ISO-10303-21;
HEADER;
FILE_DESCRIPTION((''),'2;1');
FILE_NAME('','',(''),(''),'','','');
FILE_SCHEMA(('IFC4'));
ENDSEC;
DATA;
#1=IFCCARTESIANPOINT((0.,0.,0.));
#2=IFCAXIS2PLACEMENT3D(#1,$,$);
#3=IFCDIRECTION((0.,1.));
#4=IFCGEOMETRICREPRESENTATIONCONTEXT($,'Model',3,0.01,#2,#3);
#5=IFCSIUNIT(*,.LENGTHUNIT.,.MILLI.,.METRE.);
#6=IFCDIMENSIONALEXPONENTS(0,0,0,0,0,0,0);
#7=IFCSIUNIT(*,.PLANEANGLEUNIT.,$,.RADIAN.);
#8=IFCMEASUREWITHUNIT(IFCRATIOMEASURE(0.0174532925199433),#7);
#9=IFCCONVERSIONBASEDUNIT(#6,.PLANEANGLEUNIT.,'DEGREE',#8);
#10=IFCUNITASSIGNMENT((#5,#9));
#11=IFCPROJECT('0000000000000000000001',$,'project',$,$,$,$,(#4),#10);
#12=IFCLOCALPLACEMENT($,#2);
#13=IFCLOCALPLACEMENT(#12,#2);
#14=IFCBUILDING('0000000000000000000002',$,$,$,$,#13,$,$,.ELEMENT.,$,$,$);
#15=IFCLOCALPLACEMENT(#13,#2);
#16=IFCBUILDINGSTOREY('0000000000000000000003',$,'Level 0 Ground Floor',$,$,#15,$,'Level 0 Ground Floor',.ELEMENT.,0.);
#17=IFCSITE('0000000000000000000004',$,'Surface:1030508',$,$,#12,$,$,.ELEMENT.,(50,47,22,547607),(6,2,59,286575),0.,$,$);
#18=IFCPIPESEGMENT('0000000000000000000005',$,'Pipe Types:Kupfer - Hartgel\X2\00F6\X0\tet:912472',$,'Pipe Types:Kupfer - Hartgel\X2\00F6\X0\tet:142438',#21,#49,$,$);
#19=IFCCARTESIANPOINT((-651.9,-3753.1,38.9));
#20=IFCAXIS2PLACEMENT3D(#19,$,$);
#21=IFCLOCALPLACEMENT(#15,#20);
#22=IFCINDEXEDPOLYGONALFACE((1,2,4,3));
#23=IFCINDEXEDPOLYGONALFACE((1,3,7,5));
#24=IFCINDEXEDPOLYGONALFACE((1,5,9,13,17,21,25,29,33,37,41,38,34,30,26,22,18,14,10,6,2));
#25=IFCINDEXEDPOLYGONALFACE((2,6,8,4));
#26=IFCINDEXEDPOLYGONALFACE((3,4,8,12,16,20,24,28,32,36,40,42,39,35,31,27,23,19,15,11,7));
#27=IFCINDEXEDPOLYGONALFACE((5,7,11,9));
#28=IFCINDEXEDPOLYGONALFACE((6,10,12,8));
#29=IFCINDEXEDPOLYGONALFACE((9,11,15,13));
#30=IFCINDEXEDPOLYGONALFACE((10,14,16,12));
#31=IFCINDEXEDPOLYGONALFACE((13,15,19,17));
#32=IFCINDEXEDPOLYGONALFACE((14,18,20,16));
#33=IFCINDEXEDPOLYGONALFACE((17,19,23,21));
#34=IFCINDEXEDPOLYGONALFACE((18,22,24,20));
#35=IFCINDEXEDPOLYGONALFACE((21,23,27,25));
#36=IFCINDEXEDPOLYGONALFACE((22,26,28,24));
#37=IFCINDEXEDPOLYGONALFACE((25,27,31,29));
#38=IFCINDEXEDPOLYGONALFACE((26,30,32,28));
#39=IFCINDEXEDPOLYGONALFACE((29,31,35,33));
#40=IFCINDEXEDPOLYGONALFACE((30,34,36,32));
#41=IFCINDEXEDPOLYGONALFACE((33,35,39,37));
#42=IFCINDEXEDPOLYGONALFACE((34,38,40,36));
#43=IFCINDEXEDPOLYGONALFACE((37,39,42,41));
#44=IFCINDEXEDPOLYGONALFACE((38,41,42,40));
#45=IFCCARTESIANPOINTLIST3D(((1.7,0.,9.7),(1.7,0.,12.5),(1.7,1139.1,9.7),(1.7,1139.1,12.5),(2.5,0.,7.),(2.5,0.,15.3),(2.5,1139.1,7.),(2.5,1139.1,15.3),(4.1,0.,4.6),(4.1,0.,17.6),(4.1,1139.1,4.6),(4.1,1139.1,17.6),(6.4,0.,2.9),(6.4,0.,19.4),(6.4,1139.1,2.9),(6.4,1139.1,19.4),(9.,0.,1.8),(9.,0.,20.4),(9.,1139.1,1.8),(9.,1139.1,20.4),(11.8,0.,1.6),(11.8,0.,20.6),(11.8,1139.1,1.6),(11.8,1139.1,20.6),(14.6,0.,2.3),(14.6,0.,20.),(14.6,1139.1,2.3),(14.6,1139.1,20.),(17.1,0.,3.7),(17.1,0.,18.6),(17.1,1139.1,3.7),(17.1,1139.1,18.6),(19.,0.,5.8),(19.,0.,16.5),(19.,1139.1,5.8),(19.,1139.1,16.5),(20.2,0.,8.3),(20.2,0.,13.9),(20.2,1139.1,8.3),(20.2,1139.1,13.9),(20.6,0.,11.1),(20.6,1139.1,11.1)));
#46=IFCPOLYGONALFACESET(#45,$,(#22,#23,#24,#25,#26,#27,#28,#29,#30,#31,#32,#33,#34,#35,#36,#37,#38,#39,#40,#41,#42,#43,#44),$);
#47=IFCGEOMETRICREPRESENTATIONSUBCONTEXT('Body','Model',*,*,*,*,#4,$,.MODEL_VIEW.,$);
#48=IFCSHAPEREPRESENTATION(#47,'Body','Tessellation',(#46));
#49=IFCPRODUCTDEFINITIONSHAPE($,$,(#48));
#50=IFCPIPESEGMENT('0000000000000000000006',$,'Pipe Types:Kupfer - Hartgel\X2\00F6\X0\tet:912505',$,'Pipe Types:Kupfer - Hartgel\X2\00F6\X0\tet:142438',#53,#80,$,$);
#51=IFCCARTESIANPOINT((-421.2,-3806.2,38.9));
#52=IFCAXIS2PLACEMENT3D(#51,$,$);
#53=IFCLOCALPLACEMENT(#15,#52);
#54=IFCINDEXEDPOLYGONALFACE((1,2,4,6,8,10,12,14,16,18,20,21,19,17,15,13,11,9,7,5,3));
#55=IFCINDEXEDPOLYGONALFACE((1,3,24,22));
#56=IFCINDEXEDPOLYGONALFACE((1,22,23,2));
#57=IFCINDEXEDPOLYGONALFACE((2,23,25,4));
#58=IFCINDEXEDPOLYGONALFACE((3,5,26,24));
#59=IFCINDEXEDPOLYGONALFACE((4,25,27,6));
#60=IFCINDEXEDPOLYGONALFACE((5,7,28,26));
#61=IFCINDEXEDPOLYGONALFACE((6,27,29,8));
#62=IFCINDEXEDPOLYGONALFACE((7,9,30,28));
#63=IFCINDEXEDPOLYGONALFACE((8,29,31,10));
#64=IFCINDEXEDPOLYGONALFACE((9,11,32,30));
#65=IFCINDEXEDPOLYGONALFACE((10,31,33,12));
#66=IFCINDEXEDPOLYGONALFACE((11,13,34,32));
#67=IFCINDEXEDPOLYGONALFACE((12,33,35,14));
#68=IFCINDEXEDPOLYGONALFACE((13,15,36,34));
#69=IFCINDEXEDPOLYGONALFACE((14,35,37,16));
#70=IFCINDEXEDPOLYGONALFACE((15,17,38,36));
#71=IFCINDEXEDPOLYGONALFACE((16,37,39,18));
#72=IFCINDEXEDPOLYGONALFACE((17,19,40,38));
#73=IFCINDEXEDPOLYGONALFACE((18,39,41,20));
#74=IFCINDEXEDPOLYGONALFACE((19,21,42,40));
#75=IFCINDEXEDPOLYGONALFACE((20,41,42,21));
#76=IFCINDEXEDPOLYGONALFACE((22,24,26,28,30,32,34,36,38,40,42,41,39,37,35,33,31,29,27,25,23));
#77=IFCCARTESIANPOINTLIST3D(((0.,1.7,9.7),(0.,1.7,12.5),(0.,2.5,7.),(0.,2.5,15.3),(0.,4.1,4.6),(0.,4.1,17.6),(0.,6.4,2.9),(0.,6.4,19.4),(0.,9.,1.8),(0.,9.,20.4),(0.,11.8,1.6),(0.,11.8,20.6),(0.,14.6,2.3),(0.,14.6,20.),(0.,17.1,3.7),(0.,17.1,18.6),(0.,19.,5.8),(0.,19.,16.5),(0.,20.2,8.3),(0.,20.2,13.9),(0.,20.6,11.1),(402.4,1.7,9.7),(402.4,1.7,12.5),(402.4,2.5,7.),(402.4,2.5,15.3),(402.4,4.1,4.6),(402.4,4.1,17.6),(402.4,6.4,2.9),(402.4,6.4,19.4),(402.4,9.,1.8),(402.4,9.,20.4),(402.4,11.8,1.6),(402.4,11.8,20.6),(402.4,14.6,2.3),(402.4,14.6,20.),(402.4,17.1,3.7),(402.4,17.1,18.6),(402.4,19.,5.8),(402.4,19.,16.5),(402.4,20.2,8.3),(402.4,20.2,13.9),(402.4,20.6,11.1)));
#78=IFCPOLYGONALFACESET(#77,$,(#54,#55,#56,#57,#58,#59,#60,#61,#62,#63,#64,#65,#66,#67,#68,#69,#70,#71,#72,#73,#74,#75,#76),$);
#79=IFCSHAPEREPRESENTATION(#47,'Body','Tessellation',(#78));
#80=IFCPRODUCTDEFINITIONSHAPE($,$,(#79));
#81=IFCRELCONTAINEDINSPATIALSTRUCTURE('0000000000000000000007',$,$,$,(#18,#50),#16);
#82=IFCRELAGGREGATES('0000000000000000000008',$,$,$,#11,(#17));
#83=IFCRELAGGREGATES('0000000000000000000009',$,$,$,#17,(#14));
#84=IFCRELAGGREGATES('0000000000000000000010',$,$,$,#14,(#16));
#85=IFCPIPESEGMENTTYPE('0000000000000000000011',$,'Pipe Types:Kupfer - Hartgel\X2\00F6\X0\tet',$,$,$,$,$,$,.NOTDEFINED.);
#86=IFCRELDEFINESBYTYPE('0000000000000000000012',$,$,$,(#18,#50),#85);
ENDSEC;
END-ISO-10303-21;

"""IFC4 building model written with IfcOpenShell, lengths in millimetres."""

from ifc_helpers import new_model, entity, si_unit, converted_unit, direction, frame, frame_2d, origin, place, context, subcontext, project, spatial, circle, extrude, type_object, element, save


model = new_model("IFC4")

# Units and contexts
model_context = context("Model", 3, precision=0.01, world=origin(), true_north=direction((0.0, 1.0)))
body_context = subcontext(model_context, "Body", "Model", "MODEL_VIEW")
ifc_project = project(units=[si_unit("LENGTHUNIT", "METRE", prefix="MILLI"), converted_unit("PLANEANGLEUNIT", "DEGREE", entity("IfcRatioMeasure", 0.0174532925199433), si_unit("PLANEANGLEUNIT", "RADIAN"), dimensions=[0, 0, 0, 0, 0, 0, 0])], contexts=[model_context])

# Site, building, storey
site_placement = place(None, origin())
site = spatial("IfcSite", under=ifc_project, at=site_placement, Name="Surface:1030508", CompositionType="ELEMENT", RefLatitude=(50, 47, 22, 547607), RefLongitude=(6, 2, 59, 286575), RefElevation=0.0)
building_placement = place(site_placement, origin())
building = spatial("IfcBuilding", under=site, at=building_placement, CompositionType="ELEMENT")
storey_placement = place(building_placement, origin())
storey = spatial("IfcBuildingStorey", under=building, at=storey_placement, Name="Level 0 Ground Floor", LongName="Level 0 Ground Floor", CompositionType="ELEMENT", Elevation=0.0)

# Pipe segments
pipe_segment_type = type_object("IfcPipeSegmentType", Name="Pipe Types:Kupfer - Hartgelötet", PredefinedType="NOTDEFINED")
pipe_segment_1_placement = place(storey_placement, frame((-651.9, -3753.1, 38.9)))
element("IfcPipeSegment", 1, at=pipe_segment_1_placement, inside=storey, type_object=pipe_segment_type, Name="Pipe Types:Kupfer - Hartgelötet:912472", ObjectType="Pipe Types:Kupfer - Hartgelötet:142438", context=body_context, shape_type="SweptSolid", body=[
    extrude(circle(Radius=9.5, at=frame_2d((0.0, 0.0), x_axis=(1.0, 0.0))), frame((11.1, 0.0, 11.1), z_axis=(0.0, 1.0, 0.0), x_axis=(1.0, 0.0, 0.0)), (0.0, 0.0, 1.0), 1139.1),
])
pipe_segment_2_placement = place(storey_placement, frame((-421.2, -3806.2, 38.9)))
element("IfcPipeSegment", 2, at=pipe_segment_2_placement, inside=storey, type_object=pipe_segment_type, Name="Pipe Types:Kupfer - Hartgelötet:912505", ObjectType="Pipe Types:Kupfer - Hartgelötet:142438", context=body_context, shape_type="SweptSolid", body=[
    extrude(circle(Radius=9.5, at=frame_2d((0.0, 0.0), x_axis=(1.0, 0.0))), frame((0.0, 11.1, 11.1), z_axis=(1.0, 0.0, 0.0), x_axis=(0.0, 1.0, 0.0)), (0.0, 0.0, 1.0), 402.4),
])

save(model, "model.ifc")
